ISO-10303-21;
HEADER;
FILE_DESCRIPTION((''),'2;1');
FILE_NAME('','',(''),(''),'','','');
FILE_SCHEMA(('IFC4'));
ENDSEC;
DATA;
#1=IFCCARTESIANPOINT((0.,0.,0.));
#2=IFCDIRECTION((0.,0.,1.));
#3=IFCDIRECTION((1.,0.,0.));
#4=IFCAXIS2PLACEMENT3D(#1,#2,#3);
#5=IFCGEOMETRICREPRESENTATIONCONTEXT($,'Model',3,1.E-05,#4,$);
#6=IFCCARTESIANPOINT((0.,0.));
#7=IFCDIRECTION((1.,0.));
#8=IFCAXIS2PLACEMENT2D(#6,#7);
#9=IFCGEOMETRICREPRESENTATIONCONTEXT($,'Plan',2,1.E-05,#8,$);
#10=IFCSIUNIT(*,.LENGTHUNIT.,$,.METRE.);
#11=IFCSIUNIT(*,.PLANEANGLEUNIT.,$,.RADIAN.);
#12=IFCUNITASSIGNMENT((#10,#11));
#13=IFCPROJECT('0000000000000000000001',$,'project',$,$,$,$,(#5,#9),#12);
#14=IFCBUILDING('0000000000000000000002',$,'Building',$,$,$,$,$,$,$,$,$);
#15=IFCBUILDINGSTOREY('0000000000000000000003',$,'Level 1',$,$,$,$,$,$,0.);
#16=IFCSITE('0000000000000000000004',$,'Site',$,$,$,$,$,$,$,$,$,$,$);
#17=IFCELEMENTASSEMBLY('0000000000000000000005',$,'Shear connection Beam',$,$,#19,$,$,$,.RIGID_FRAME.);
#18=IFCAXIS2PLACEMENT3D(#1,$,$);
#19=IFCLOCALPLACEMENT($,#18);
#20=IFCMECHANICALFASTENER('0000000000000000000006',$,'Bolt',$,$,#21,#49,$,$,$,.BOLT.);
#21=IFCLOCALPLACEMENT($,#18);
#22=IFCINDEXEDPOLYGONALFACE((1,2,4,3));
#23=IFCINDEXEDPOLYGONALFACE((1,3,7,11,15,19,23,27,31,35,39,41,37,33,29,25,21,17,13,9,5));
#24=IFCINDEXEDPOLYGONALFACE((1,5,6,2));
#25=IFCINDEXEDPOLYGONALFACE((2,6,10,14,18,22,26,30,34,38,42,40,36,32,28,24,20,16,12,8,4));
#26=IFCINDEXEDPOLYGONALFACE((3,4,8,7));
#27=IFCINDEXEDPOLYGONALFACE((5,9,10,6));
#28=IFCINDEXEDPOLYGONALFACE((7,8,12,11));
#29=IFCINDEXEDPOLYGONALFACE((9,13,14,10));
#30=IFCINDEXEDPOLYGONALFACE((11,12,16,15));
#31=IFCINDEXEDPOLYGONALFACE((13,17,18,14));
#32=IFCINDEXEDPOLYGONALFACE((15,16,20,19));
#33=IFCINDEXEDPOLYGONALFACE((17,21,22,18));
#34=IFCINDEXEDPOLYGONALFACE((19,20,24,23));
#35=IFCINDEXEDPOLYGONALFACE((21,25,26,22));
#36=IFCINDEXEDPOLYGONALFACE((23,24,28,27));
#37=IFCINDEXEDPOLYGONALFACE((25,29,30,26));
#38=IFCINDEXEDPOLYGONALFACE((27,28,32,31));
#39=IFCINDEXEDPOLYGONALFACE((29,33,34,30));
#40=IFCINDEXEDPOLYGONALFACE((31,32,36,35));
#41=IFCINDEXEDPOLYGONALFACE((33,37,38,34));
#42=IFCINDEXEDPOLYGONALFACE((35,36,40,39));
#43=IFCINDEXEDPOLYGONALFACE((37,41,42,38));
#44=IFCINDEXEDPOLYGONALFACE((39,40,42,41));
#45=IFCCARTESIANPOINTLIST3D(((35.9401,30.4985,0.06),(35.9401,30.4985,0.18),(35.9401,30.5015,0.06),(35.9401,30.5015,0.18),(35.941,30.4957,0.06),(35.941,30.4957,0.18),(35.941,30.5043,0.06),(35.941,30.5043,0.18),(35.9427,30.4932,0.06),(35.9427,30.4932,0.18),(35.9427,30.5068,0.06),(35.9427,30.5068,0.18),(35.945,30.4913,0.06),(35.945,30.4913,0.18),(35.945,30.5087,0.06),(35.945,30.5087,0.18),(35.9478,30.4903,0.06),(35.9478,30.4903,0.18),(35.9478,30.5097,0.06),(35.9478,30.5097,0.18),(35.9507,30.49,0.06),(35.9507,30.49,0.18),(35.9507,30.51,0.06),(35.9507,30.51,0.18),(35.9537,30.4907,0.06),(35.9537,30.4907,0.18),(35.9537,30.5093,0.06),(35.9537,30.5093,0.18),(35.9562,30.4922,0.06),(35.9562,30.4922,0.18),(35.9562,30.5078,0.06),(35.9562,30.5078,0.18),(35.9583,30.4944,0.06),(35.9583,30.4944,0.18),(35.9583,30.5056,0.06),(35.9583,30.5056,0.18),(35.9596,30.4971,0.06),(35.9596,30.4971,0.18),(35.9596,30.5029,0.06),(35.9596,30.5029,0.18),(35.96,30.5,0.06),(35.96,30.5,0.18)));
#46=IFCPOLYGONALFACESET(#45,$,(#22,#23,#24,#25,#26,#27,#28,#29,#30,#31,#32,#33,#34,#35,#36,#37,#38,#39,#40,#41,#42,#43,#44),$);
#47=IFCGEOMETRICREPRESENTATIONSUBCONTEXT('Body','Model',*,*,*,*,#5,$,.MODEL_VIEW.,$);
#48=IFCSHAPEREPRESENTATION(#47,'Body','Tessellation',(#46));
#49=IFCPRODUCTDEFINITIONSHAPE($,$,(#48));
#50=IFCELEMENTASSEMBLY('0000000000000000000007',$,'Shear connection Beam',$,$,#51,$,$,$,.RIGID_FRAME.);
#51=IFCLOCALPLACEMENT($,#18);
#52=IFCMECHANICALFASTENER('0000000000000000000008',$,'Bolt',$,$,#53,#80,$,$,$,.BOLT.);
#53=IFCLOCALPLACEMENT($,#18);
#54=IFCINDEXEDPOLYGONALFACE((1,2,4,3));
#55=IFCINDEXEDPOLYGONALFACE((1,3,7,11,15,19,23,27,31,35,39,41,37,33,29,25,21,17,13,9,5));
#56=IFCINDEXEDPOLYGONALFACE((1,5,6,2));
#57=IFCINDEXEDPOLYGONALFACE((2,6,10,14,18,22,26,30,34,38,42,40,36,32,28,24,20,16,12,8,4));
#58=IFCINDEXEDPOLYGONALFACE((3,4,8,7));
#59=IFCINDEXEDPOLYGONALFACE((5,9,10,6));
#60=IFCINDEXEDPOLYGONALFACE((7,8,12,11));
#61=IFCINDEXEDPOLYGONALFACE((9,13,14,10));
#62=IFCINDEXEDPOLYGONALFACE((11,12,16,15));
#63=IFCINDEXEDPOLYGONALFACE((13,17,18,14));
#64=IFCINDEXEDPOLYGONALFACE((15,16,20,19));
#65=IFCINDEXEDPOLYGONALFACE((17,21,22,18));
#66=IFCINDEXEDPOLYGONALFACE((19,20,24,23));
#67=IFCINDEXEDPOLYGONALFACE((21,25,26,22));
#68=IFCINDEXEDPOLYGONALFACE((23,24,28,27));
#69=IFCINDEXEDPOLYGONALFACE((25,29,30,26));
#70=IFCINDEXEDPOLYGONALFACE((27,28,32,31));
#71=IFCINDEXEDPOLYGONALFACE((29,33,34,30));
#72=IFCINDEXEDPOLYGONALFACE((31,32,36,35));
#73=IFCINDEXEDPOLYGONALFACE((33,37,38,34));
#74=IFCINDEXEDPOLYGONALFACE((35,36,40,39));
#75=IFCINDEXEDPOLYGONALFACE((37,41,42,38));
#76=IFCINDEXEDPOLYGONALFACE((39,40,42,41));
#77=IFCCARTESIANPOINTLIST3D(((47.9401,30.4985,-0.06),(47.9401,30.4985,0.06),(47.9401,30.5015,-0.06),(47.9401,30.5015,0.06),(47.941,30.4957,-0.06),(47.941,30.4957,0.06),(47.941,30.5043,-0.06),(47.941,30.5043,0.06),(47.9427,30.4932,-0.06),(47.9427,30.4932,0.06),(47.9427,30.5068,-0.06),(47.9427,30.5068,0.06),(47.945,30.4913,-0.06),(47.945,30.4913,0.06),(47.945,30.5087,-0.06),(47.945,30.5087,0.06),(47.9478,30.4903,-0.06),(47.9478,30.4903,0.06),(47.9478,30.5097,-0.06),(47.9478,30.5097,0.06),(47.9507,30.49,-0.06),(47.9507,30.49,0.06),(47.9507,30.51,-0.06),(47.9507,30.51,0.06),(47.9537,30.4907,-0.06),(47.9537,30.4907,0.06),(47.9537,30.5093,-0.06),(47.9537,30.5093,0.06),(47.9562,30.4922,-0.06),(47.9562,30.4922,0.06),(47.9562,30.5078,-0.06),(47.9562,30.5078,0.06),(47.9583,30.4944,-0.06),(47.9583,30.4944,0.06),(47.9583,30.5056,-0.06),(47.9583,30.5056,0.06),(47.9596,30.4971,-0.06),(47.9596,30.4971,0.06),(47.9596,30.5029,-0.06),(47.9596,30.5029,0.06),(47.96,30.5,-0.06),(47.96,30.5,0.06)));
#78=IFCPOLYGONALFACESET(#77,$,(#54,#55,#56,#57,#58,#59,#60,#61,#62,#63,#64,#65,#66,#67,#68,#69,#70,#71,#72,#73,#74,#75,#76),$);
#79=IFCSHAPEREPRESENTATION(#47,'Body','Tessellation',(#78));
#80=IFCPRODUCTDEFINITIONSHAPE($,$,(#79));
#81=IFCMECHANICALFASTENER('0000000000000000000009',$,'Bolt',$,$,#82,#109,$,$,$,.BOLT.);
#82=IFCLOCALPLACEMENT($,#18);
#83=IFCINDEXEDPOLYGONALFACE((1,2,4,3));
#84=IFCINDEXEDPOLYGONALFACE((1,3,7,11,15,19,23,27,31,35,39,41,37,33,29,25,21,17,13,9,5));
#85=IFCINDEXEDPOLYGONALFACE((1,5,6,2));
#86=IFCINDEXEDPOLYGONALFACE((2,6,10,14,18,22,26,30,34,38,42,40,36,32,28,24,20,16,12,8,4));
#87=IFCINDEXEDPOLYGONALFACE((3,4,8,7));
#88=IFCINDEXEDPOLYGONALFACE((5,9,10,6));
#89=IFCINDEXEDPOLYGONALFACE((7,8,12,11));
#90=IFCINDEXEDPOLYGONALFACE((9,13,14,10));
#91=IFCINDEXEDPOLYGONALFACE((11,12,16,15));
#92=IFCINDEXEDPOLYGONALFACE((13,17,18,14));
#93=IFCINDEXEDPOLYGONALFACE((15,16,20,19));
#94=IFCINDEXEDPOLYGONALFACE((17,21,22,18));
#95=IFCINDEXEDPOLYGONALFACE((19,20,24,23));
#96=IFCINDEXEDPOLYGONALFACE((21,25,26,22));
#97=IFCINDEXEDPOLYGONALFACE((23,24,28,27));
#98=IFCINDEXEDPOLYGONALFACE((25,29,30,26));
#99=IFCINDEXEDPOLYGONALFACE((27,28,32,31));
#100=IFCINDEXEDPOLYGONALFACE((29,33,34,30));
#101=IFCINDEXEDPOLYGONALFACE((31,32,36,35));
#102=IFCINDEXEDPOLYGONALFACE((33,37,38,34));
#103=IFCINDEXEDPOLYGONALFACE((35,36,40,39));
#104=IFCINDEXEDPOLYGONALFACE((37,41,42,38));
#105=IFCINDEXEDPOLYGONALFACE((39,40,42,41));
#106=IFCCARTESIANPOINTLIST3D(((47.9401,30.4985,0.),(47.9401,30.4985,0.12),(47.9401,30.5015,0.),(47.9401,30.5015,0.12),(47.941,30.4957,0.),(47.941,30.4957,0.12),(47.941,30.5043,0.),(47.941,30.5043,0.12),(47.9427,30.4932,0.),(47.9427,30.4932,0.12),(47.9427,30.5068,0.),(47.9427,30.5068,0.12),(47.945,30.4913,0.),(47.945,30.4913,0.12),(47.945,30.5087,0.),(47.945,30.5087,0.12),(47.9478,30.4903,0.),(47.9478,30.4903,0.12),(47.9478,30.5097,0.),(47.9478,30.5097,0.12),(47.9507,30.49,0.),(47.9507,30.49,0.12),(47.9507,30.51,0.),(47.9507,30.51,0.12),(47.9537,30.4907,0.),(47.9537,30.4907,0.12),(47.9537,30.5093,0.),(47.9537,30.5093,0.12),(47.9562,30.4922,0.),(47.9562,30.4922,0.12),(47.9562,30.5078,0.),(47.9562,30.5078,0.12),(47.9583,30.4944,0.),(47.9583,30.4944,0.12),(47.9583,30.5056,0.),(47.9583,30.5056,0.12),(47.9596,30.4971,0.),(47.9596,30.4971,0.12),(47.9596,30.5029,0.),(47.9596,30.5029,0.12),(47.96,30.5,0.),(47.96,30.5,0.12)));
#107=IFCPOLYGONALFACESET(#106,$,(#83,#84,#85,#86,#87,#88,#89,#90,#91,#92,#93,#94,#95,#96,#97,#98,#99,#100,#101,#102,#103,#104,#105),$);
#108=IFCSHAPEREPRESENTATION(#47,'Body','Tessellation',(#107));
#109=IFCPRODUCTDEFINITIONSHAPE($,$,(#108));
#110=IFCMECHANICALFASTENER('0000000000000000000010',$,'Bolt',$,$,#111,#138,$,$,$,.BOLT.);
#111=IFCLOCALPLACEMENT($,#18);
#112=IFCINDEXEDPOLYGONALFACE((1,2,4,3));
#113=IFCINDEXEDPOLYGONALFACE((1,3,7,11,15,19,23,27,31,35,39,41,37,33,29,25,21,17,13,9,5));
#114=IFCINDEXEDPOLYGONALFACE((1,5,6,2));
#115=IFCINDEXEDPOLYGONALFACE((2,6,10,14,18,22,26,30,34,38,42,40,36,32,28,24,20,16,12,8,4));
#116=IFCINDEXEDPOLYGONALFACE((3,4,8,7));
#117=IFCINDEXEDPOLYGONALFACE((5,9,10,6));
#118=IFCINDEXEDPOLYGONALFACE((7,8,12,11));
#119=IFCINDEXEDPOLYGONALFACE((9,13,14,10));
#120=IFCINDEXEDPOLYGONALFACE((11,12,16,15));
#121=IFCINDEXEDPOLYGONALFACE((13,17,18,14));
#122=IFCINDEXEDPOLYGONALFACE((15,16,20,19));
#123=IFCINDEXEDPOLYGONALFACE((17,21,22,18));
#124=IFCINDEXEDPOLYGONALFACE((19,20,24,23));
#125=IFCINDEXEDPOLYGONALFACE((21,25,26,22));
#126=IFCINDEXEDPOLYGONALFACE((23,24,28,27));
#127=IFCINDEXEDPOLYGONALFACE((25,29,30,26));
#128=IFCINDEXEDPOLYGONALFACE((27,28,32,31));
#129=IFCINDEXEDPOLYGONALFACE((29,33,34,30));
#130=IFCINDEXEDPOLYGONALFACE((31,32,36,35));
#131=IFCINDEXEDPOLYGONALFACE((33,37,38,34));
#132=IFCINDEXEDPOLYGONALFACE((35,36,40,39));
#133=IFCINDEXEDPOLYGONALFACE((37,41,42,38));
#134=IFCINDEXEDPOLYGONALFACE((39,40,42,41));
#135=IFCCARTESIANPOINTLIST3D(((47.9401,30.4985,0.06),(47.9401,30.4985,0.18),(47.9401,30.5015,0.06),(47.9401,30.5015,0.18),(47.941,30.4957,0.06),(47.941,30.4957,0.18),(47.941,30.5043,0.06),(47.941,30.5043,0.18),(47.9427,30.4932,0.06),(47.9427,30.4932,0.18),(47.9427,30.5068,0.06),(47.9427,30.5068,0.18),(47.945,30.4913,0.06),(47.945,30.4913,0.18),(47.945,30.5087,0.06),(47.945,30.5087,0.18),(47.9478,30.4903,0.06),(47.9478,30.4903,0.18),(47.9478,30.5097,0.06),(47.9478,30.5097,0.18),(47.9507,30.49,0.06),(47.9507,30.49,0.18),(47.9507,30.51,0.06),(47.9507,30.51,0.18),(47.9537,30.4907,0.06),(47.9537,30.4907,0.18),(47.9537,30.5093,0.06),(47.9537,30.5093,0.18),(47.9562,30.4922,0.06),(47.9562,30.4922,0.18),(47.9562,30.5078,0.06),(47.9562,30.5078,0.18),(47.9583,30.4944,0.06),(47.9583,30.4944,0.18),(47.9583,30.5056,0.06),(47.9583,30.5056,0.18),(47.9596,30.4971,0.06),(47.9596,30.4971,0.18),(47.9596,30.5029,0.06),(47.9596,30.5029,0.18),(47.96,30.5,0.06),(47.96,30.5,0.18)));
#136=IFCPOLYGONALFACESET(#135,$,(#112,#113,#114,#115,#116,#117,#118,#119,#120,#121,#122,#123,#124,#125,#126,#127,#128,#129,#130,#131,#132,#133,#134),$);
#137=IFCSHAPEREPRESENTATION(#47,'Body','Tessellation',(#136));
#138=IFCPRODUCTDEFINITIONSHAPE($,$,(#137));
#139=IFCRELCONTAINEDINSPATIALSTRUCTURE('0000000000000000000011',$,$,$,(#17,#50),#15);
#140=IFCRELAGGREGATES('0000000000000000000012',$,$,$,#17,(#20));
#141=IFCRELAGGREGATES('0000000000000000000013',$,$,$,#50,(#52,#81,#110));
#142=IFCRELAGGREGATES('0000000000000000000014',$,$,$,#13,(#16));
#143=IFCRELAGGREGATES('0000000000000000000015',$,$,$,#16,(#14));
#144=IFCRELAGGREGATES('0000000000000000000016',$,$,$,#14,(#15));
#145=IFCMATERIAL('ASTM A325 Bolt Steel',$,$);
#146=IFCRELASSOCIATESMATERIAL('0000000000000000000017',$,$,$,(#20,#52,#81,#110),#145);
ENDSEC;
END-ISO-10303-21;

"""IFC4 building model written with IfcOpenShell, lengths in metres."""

from ifc_helpers import new_model, si_unit, frame, origin_with_axes, origin_2d, origin_2d_with_axis, place, context, subcontext, project, spatial, circle, extrude, material, element, aggregate, save


model = new_model("IFC4")

# Units and contexts
model_context = context("Model", 3, precision=1e-05, world=origin_with_axes())
plan_context = context("Plan", 2, precision=1e-05, world=origin_2d_with_axis())
body_context = subcontext(model_context, "Body", "Model", "MODEL_VIEW")
ifc_project = project(units=[si_unit("LENGTHUNIT", "METRE"), si_unit("PLANEANGLEUNIT", "RADIAN")], contexts=[model_context, plan_context])

# Site, building, storey
site = spatial("IfcSite", under=ifc_project, Name="Site")
building = spatial("IfcBuilding", under=site, Name="Building")
storey = spatial("IfcBuildingStorey", under=building, Name="Level 1", Elevation=0.0)

# Element assembly
assembly_1 = element("IfcElementAssembly", 1, inside=storey, Name="Shear connection Beam", PredefinedType="RIGID_FRAME")

# Shared definitions
ifc_material_1 = material(Name="ASTM A325 Bolt Steel")

# Mechanical fastener
mechanical_fastener_1_placement = place(None, frame((35.95, 30.5, 0.06), z_axis=(0.0, 0.0, 1.0), x_axis=(1.0, 0.0, 0.0)))
mechanical_fastener_1 = element("IfcMechanicalFastener", 2, at=mechanical_fastener_1_placement, material=ifc_material_1, Name="Bolt", PredefinedType="BOLT", context=body_context, shape_type="SweptSolid", body=[
    extrude(circle(Radius=0.01, at=origin_2d()), origin_with_axes(), (0.0, 0.0, 1.0), 0.12),
])
aggregate(assembly_1, [mechanical_fastener_1])

# Element assembly, mechanical fasteners
assembly_2 = element("IfcElementAssembly", 3, inside=storey, Name="Shear connection Beam", PredefinedType="RIGID_FRAME")
mechanical_fastener_2_placement = place(None, frame((47.95, 30.5, -0.06), z_axis=(0.0, 0.0, 1.0), x_axis=(1.0, 0.0, 0.0)))
mechanical_fastener_2 = element("IfcMechanicalFastener", 4, at=mechanical_fastener_2_placement, material=ifc_material_1, Name="Bolt", PredefinedType="BOLT", context=body_context, shape_type="SweptSolid", body=[
    extrude(circle(Radius=0.01, at=origin_2d()), origin_with_axes(), (0.0, 0.0, 1.0), 0.12),
])
mechanical_fastener_3_placement = place(None, frame((47.95, 30.5, 0.0), z_axis=(0.0, 0.0, 1.0), x_axis=(1.0, 0.0, 0.0)))
mechanical_fastener_3 = element("IfcMechanicalFastener", 5, at=mechanical_fastener_3_placement, material=ifc_material_1, Name="Bolt", PredefinedType="BOLT", context=body_context, shape_type="SweptSolid", body=[
    extrude(circle(Radius=0.01, at=origin_2d()), origin_with_axes(), (0.0, 0.0, 1.0), 0.12),
])
mechanical_fastener_4_placement = place(None, frame((47.95, 30.5, 0.06), z_axis=(0.0, 0.0, 1.0), x_axis=(1.0, 0.0, 0.0)))
mechanical_fastener_4 = element("IfcMechanicalFastener", 6, at=mechanical_fastener_4_placement, material=ifc_material_1, Name="Bolt", PredefinedType="BOLT", context=body_context, shape_type="SweptSolid", body=[
    extrude(circle(Radius=0.01, at=origin_2d()), origin_with_axes(), (0.0, 0.0, 1.0), 0.12),
])
aggregate(assembly_2, [mechanical_fastener_2, mechanical_fastener_3, mechanical_fastener_4])

save(model, "model.ifc")
